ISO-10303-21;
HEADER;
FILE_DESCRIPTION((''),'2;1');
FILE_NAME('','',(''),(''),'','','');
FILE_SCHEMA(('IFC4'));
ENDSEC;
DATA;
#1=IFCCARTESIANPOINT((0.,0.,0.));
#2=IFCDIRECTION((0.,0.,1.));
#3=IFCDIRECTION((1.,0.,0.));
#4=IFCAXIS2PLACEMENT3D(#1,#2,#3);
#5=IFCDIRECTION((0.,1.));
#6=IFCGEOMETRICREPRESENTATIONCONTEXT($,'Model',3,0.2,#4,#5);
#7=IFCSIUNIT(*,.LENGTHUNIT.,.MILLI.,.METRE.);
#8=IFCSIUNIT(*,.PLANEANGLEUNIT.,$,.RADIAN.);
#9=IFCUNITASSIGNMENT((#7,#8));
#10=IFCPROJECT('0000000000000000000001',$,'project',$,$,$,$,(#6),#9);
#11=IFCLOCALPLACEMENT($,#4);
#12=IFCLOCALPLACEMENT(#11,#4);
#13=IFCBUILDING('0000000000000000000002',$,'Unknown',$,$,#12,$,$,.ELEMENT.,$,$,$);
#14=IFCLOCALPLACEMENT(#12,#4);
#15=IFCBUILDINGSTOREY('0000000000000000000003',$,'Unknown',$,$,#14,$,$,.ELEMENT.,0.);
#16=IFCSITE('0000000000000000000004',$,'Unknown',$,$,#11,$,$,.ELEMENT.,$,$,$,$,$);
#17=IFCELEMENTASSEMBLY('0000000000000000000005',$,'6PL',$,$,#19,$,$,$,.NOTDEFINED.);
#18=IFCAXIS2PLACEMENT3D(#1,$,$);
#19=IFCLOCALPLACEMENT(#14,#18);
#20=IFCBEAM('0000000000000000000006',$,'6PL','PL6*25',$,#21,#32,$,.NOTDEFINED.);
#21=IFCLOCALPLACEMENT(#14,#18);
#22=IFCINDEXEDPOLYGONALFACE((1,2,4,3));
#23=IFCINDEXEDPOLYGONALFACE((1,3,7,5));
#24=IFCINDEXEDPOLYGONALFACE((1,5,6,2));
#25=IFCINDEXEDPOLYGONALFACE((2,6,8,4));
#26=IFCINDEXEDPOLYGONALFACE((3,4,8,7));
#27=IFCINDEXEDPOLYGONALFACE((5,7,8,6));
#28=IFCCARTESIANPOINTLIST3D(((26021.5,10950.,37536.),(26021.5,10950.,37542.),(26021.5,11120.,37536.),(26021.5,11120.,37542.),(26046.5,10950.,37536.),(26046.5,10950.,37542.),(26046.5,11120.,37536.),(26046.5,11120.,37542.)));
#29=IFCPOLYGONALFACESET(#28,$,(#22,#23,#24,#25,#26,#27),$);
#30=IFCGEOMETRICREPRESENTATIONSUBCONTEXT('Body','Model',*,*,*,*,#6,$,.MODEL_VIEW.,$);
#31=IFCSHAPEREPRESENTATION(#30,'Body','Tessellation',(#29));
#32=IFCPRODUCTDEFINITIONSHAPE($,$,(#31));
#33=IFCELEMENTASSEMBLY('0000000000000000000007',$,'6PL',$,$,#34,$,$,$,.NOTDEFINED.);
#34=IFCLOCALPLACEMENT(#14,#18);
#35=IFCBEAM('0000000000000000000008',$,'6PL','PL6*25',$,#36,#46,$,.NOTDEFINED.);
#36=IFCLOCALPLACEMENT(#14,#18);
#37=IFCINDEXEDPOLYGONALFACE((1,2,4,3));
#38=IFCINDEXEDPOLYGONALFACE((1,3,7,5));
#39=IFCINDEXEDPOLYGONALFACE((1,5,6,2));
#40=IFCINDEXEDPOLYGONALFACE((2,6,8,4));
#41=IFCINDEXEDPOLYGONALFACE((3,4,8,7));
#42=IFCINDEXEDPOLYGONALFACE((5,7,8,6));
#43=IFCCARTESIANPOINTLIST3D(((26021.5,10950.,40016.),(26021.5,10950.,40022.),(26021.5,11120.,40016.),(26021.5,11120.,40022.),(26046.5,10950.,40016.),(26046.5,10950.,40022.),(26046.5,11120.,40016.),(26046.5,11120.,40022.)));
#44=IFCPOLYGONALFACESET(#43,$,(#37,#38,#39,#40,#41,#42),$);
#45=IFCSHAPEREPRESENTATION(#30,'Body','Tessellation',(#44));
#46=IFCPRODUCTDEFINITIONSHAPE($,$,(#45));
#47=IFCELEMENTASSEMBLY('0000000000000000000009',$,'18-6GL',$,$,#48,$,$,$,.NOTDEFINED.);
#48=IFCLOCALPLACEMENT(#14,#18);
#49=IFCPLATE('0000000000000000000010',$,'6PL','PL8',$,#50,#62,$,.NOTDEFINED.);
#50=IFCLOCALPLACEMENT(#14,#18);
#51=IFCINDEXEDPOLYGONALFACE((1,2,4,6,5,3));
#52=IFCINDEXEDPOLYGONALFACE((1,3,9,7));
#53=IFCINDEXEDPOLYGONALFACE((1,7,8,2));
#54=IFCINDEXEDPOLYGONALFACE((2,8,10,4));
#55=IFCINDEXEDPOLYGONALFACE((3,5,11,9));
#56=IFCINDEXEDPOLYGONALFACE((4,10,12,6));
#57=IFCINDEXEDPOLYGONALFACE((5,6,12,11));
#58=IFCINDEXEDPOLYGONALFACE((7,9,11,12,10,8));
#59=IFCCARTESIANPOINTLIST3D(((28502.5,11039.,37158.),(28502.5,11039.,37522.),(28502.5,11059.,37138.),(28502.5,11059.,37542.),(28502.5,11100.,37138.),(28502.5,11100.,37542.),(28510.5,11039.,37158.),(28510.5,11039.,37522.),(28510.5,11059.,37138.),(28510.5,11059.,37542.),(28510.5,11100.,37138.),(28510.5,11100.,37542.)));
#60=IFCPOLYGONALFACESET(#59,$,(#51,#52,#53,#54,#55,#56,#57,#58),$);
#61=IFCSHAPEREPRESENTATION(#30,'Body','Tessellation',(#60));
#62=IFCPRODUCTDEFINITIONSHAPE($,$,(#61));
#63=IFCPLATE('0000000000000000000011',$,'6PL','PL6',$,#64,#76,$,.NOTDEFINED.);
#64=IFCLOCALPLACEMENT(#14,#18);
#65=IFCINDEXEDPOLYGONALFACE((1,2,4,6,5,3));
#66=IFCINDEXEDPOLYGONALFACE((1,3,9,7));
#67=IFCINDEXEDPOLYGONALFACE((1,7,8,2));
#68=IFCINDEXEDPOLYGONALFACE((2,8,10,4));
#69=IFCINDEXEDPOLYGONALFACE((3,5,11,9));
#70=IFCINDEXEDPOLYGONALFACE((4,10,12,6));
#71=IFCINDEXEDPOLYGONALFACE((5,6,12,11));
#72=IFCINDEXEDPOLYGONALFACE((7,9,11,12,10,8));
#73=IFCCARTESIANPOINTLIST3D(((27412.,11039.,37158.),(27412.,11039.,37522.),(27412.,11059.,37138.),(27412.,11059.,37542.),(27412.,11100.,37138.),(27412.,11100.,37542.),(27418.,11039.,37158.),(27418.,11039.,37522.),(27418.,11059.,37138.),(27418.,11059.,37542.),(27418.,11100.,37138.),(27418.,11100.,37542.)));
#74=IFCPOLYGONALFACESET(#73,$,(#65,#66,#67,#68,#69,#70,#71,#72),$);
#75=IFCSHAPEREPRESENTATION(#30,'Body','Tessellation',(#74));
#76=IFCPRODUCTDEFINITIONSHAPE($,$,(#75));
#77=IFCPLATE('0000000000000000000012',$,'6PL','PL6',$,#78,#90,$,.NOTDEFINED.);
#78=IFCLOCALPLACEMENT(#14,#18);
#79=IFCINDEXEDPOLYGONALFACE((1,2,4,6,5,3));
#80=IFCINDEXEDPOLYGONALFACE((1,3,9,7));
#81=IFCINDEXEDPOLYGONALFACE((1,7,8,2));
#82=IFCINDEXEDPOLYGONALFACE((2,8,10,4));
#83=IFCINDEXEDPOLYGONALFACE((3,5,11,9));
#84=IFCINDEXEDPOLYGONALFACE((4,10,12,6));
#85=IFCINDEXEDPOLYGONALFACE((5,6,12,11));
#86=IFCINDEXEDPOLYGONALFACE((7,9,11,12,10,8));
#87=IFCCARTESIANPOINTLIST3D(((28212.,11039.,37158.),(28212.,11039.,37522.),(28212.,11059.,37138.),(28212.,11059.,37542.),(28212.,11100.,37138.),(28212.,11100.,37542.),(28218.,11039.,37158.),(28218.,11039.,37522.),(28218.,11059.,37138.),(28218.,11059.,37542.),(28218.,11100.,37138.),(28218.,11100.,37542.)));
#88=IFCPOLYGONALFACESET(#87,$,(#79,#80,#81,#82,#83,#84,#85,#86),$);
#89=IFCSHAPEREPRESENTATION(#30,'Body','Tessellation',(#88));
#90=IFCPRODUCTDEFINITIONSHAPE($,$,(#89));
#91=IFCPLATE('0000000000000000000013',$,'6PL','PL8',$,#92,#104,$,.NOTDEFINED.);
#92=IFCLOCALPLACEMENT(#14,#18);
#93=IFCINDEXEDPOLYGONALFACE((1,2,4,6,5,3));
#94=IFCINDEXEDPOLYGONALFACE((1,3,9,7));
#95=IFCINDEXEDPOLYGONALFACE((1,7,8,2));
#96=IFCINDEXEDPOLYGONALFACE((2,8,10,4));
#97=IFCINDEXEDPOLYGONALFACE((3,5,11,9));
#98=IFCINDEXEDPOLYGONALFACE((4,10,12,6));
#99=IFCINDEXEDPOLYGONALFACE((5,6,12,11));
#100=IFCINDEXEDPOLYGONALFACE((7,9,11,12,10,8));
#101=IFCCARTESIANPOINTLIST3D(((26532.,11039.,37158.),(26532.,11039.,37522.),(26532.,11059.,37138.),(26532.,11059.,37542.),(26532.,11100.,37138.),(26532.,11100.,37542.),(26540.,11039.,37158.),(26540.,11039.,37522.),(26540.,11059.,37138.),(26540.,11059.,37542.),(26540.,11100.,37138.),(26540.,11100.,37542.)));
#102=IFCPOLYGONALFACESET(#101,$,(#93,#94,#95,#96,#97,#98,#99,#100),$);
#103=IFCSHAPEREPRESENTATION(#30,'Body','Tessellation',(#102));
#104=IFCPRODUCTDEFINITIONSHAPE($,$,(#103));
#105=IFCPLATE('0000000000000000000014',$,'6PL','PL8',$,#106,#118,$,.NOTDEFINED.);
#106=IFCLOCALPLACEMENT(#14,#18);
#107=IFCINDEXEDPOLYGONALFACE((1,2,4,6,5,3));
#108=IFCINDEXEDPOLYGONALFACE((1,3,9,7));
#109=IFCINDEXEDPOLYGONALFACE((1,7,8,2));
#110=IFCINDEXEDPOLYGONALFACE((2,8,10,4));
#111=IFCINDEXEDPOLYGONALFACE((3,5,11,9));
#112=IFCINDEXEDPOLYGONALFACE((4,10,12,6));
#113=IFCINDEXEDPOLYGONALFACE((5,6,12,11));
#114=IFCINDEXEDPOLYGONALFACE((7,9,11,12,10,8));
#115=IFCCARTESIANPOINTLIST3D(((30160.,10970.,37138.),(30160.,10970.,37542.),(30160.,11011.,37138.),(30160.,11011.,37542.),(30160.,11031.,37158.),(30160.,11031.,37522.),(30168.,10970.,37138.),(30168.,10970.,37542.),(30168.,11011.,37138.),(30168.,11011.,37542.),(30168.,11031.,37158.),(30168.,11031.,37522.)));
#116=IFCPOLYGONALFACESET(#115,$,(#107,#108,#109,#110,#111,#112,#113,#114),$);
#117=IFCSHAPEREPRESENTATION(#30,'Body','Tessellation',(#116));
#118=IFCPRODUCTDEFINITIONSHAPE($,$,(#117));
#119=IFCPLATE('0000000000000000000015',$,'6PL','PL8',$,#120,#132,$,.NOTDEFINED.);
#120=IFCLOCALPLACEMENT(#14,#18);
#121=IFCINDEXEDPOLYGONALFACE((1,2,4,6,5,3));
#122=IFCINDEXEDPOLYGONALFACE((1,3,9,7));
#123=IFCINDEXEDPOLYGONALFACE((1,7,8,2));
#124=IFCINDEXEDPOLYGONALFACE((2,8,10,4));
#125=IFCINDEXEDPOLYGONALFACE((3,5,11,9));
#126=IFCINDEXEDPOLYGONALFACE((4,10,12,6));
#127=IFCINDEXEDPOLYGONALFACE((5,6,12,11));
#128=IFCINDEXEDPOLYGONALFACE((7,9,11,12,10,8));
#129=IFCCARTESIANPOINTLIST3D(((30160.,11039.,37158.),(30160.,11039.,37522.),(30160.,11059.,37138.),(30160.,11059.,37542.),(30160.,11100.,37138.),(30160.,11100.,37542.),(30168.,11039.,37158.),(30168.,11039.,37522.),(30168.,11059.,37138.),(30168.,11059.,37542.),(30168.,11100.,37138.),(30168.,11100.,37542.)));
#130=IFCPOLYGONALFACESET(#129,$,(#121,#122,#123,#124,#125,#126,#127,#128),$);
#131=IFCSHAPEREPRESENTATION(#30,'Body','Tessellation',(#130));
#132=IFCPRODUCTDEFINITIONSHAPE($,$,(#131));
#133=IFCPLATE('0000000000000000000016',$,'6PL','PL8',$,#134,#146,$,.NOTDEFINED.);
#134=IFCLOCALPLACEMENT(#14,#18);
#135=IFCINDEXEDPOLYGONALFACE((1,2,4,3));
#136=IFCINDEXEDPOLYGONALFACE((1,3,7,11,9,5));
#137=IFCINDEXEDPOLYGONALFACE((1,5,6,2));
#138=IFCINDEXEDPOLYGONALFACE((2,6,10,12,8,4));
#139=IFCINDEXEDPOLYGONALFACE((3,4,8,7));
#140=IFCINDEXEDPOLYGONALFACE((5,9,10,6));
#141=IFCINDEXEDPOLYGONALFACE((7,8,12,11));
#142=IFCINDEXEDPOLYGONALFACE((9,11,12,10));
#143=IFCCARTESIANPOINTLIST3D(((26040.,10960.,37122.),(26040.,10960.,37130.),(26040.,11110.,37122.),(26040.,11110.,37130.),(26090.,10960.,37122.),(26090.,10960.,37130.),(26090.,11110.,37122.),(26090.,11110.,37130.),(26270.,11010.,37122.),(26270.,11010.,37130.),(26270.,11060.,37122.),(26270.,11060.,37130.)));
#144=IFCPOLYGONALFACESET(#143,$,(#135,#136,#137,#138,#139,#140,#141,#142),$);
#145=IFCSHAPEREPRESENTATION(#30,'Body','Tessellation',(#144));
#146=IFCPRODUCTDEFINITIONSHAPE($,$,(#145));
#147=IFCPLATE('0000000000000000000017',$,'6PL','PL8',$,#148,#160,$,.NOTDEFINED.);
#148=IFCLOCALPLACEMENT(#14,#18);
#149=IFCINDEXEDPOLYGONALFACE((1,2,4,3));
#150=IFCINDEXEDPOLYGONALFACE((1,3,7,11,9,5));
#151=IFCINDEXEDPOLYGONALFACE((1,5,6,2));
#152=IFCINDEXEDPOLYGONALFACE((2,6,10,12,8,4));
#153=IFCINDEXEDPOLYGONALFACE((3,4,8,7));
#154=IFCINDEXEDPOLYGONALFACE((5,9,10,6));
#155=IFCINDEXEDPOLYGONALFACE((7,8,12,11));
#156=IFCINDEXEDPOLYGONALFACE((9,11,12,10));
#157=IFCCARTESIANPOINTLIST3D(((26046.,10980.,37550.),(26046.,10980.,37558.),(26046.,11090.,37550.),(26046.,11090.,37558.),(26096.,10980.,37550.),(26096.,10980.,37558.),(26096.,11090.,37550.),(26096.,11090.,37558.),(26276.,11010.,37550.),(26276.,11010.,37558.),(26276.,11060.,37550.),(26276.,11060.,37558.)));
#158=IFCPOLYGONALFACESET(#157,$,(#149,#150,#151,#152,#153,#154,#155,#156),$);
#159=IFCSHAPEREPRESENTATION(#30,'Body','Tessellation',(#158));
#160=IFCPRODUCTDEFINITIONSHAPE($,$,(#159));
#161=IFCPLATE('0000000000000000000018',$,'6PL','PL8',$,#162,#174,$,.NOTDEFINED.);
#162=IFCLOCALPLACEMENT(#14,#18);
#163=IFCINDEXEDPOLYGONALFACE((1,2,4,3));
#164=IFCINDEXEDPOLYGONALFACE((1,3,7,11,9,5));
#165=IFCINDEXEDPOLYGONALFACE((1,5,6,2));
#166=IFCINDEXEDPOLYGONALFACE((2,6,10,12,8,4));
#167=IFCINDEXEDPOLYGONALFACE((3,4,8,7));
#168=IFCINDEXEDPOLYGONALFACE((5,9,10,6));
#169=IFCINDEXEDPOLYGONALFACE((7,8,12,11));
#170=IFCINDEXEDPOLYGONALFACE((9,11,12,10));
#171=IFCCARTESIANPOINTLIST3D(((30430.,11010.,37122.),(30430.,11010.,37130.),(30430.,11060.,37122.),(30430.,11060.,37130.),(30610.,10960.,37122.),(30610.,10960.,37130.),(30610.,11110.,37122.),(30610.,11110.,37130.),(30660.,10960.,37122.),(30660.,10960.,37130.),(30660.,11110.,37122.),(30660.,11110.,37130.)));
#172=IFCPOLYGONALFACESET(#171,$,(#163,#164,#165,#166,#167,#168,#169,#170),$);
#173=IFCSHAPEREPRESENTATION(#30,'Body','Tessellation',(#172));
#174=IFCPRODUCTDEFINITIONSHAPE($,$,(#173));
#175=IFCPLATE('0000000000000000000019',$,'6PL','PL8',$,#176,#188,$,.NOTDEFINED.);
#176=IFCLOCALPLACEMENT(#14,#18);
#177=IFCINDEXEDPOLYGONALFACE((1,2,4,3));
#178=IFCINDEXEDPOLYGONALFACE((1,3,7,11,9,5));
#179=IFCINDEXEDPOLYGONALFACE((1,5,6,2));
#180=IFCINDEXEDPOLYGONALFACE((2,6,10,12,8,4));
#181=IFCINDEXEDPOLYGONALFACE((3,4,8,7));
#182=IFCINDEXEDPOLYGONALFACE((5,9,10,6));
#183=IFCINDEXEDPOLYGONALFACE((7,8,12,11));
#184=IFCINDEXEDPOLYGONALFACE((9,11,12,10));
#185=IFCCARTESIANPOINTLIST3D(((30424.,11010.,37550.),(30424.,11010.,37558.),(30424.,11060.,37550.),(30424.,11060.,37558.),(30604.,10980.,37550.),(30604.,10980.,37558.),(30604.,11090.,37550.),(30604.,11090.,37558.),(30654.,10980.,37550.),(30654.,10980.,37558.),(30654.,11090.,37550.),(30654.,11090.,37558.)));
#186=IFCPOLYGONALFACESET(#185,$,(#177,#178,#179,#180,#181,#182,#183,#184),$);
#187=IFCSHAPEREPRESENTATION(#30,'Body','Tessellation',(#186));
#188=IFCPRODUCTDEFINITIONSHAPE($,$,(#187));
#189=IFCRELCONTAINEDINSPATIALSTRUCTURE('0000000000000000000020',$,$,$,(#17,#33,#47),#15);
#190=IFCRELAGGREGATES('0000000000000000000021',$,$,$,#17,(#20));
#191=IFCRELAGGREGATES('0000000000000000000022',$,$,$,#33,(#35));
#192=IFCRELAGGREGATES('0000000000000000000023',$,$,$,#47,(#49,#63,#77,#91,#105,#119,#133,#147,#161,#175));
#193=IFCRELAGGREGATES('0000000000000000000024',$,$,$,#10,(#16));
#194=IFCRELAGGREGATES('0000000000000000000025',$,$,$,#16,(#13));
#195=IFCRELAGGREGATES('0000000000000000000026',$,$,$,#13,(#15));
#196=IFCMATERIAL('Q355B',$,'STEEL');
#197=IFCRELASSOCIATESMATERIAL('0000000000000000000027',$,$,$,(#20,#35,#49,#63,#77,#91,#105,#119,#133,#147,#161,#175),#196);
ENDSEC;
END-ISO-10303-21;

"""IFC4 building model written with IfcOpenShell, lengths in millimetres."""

from ifc_helpers import new_model, si_unit, direction, frame, origin_with_axes, place, context, subcontext, project, spatial, line, indexed_curve, outline, extrude, material, element, aggregate, save


model = new_model("IFC4")

# Units and contexts
model_context = context("Model", 3, precision=0.2, world=origin_with_axes(), true_north=direction((0.0, 1.0)))
body_context = subcontext(model_context, "Body", "Model", "MODEL_VIEW")
ifc_project = project(units=[si_unit("LENGTHUNIT", "METRE", prefix="MILLI"), si_unit("PLANEANGLEUNIT", "RADIAN")], contexts=[model_context])

# Site, building, storey
site_placement = place(None, origin_with_axes())
site = spatial("IfcSite", under=ifc_project, at=site_placement, Name="Unknown", CompositionType="ELEMENT")
building_placement = place(site_placement, origin_with_axes())
building = spatial("IfcBuilding", under=site, at=building_placement, Name="Unknown", CompositionType="ELEMENT")
storey_placement = place(building_placement, origin_with_axes())
storey = spatial("IfcBuildingStorey", under=building, at=storey_placement, Name="Unknown", CompositionType="ELEMENT", Elevation=0.0)

# Element assemblies, beams
assembly_1_placement = place(storey_placement, frame((26034.0, 10950.0, 37539.0), z_axis=(0.0, 0.0, -1.0), x_axis=(0.0, 1.0, 0.0)))
assembly_1 = element("IfcElementAssembly", 1, at=assembly_1_placement, inside=storey, Name="6PL", PredefinedType="NOTDEFINED")
ifc_material_1 = material(Name="Q355B", Category="STEEL")
beam_1_placement = place(assembly_1_placement, origin_with_axes())
beam_1 = element("IfcBeam", 2, at=beam_1_placement, material=ifc_material_1, Name="6PL", Description="PL6*25", PredefinedType="NOTDEFINED", context=body_context, shape_type="SolidModel", body=[
    extrude(outline(indexed_curve([(-3.0, -12.5), (3.0, -12.5), (3.0, 12.5), (-3.0, 12.5)], segments=[line(1, 2, 3, 4, 1)])), frame((0.0, 0.0, 0.0), z_axis=(-1.0, 0.0, 0.0), x_axis=(0.0, 0.0, 1.0)), (0.0, 0.0, -1.0), 170.0),
])
aggregate(assembly_1, [beam_1])
assembly_2_placement = place(storey_placement, frame((26034.0, 10950.0, 40019.0), z_axis=(0.0, 0.0, -1.0), x_axis=(0.0, 1.0, 0.0)))
assembly_2 = element("IfcElementAssembly", 3, at=assembly_2_placement, inside=storey, Name="6PL", PredefinedType="NOTDEFINED")
beam_2_placement = place(assembly_2_placement, origin_with_axes())
beam_2 = element("IfcBeam", 4, at=beam_2_placement, material=ifc_material_1, Name="6PL", Description="PL6*25", PredefinedType="NOTDEFINED", context=body_context, shape_type="SolidModel", body=[
    extrude(outline(indexed_curve([(-3.0, -12.5), (3.0, -12.5), (3.0, 12.5), (-3.0, 12.5)], segments=[line(1, 2, 3, 4, 1)])), frame((0.0, 0.0, 0.0), z_axis=(-1.0, 0.0, 0.0), x_axis=(0.0, 0.0, 1.0)), (0.0, 0.0, -1.0), 170.0),
])
aggregate(assembly_2, [beam_2])

# Element assembly, plates
assembly_3_placement = place(storey_placement, frame((26000.0, 11035.0, 37340.0), z_axis=(0.0, -1.0, 0.0), x_axis=(1.0, 0.0, 0.0)))
assembly_3 = element("IfcElementAssembly", 5, at=assembly_3_placement, inside=storey, Name="18-6GL", PredefinedType="NOTDEFINED")
plate_1_placement = place(assembly_3_placement, frame((2506.5, -202.0, -4.0), z_axis=(1.0, 0.0, 0.0), x_axis=(0.0, 0.0, -1.0)))
plate_1 = element("IfcPlate", 6, at=plate_1_placement, material=ifc_material_1, Name="6PL", Description="PL8", PredefinedType="NOTDEFINED", context=body_context, shape_type="SolidModel", body=[
    extrude(outline(indexed_curve([(0.0, 20.0), (20.0, 0.0), (61.0, 0.0), (61.0, 404.0), (20.0, 404.0), (0.0, 384.0)], segments=[line(1, 2, 3, 4, 5, 6, 1)])), frame((0.0, 0.0, 4.0), z_axis=(0.0, 0.0, 1.0), x_axis=(1.0, 0.0, 0.0)), (0.0, 0.0, -1.0), 8.0),
])
plate_2_placement = place(assembly_3_placement, frame((1415.0, -202.0, -4.0), z_axis=(1.0, 0.0, 0.0), x_axis=(0.0, 0.0, -1.0)))
plate_2 = element("IfcPlate", 7, at=plate_2_placement, material=ifc_material_1, Name="6PL", Description="PL6", PredefinedType="NOTDEFINED", context=body_context, shape_type="SolidModel", body=[
    extrude(outline(indexed_curve([(0.0, 20.0), (20.0, 0.0), (61.0, 0.0), (61.0, 404.0), (20.0, 404.0), (0.0, 384.0)], segments=[line(1, 2, 3, 4, 5, 6, 1)])), frame((0.0, 0.0, 3.0), z_axis=(0.0, 0.0, 1.0), x_axis=(1.0, 0.0, 0.0)), (0.0, 0.0, -1.0), 6.0),
])
plate_3_placement = place(assembly_3_placement, frame((2215.0, -202.0, -4.0), z_axis=(1.0, 0.0, 0.0), x_axis=(0.0, 0.0, -1.0)))
plate_3 = element("IfcPlate", 8, at=plate_3_placement, material=ifc_material_1, Name="6PL", Description="PL6", PredefinedType="NOTDEFINED", context=body_context, shape_type="SolidModel", body=[
    extrude(outline(indexed_curve([(0.0, 20.0), (20.0, 0.0), (61.0, 0.0), (61.0, 404.0), (20.0, 404.0), (0.0, 384.0)], segments=[line(1, 2, 3, 4, 5, 6, 1)])), frame((0.0, 0.0, 3.0), z_axis=(0.0, 0.0, 1.0), x_axis=(1.0, 0.0, 0.0)), (0.0, 0.0, -1.0), 6.0),
])
plate_4_placement = place(assembly_3_placement, frame((536.0, -202.0, -4.0), z_axis=(1.0, 0.0, 0.0), x_axis=(0.0, 0.0, -1.0)))
plate_4 = element("IfcPlate", 9, at=plate_4_placement, material=ifc_material_1, Name="6PL", Description="PL8", PredefinedType="NOTDEFINED", context=body_context, shape_type="SolidModel", body=[
    extrude(outline(indexed_curve([(0.0, 20.0), (20.0, 0.0), (61.0, 0.0), (61.0, 404.0), (20.0, 404.0), (0.0, 384.0)], segments=[line(1, 2, 3, 4, 5, 6, 1)])), frame((0.0, 0.0, 4.0), z_axis=(0.0, 0.0, 1.0), x_axis=(1.0, 0.0, 0.0)), (0.0, 0.0, -1.0), 8.0),
])
plate_5_placement = place(assembly_3_placement, frame((4164.0, -202.0, 65.0), z_axis=(1.0, 0.0, 0.0), x_axis=(0.0, 0.0, -1.0)))
plate_5 = element("IfcPlate", 10, at=plate_5_placement, material=ifc_material_1, Name="6PL", Description="PL8", PredefinedType="NOTDEFINED", context=body_context, shape_type="SolidModel", body=[
    extrude(outline(indexed_curve([(0.0, 0.0), (41.0, 0.0), (61.0, 20.0), (61.0, 384.0), (41.0, 404.0), (0.0, 404.0)], segments=[line(1, 2, 3, 4, 5, 6, 1)])), frame((0.0, 0.0, 4.0), z_axis=(0.0, 0.0, 1.0), x_axis=(1.0, 0.0, 0.0)), (0.0, 0.0, -1.0), 8.0),
])
plate_6_placement = place(assembly_3_placement, frame((4164.0, -202.0, -4.0), z_axis=(1.0, 0.0, 0.0), x_axis=(0.0, 0.0, -1.0)))
plate_6 = element("IfcPlate", 11, at=plate_6_placement, material=ifc_material_1, Name="6PL", Description="PL8", PredefinedType="NOTDEFINED", context=body_context, shape_type="SolidModel", body=[
    extrude(outline(indexed_curve([(0.0, 20.0), (20.0, 0.0), (61.0, 0.0), (61.0, 404.0), (20.0, 404.0), (0.0, 384.0)], segments=[line(1, 2, 3, 4, 5, 6, 1)])), frame((0.0, 0.0, 4.0), z_axis=(0.0, 0.0, 1.0), x_axis=(1.0, 0.0, 0.0)), (0.0, 0.0, -1.0), 8.0),
])
plate_7_placement = place(assembly_3_placement, frame((90.0, -214.0, -75.0), z_axis=(0.0, 1.0, 0.0), x_axis=(-1.0, 0.0, 0.0)))
plate_7 = element("IfcPlate", 12, at=plate_7_placement, material=ifc_material_1, Name="6PL", Description="PL8", PredefinedType="NOTDEFINED", context=body_context, shape_type="SolidModel", body=[
    extrude(outline(indexed_curve([(0.0, 0.0), (50.0, 0.0), (50.0, 150.0), (0.0, 150.0), (-180.0, 100.0), (-180.0, 50.0)], segments=[line(1, 2, 3, 4, 5, 6, 1)])), frame((0.0, 0.0, 4.0), z_axis=(0.0, 0.0, 1.0), x_axis=(1.0, 0.0, 0.0)), (0.0, 0.0, -1.0), 8.0),
])
plate_8_placement = place(assembly_3_placement, frame((96.0, 214.0, -55.0), z_axis=(0.0, 1.0, 0.0), x_axis=(-1.0, 0.0, 0.0)))
plate_8 = element("IfcPlate", 13, at=plate_8_placement, material=ifc_material_1, Name="6PL", Description="PL8", PredefinedType="NOTDEFINED", context=body_context, shape_type="SolidModel", body=[
    extrude(outline(indexed_curve([(0.0, 0.0), (50.0, 0.0), (50.0, 110.0), (0.0, 110.0), (-180.0, 80.0), (-180.0, 30.0)], segments=[line(1, 2, 3, 4, 5, 6, 1)])), frame((0.0, 0.0, 4.0), z_axis=(0.0, 0.0, 1.0), x_axis=(1.0, 0.0, 0.0)), (0.0, 0.0, -1.0), 8.0),
])
plate_9_placement = place(assembly_3_placement, frame((4610.0, -214.0, 75.0), z_axis=(0.0, 1.0, 0.0), x_axis=(1.0, 0.0, 0.0)))
plate_9 = element("IfcPlate", 14, at=plate_9_placement, material=ifc_material_1, Name="6PL", Description="PL8", PredefinedType="NOTDEFINED", context=body_context, shape_type="SolidModel", body=[
    extrude(outline(indexed_curve([(0.0, 0.0), (50.0, 0.0), (50.0, 150.0), (0.0, 150.0), (-180.0, 100.0), (-180.0, 50.0)], segments=[line(1, 2, 3, 4, 5, 6, 1)])), frame((0.0, 0.0, 4.0), z_axis=(0.0, 0.0, 1.0), x_axis=(1.0, 0.0, 0.0)), (0.0, 0.0, -1.0), 8.0),
])
plate_10_placement = place(assembly_3_placement, frame((4604.0, 214.0, 55.0), z_axis=(0.0, 1.0, 0.0), x_axis=(1.0, 0.0, 0.0)))
plate_10 = element("IfcPlate", 15, at=plate_10_placement, material=ifc_material_1, Name="6PL", Description="PL8", PredefinedType="NOTDEFINED", context=body_context, shape_type="SolidModel", body=[
    extrude(outline(indexed_curve([(0.0, 0.0), (50.0, 0.0), (50.0, 110.0), (0.0, 110.0), (-180.0, 80.0), (-180.0, 30.0)], segments=[line(1, 2, 3, 4, 5, 6, 1)])), frame((0.0, 0.0, 4.0), z_axis=(0.0, 0.0, 1.0), x_axis=(1.0, 0.0, 0.0)), (0.0, 0.0, -1.0), 8.0),
])
aggregate(assembly_3, [plate_1, plate_2, plate_3, plate_4, plate_5, plate_6, plate_7, plate_8, plate_9, plate_10])

save(model, "model.ifc")
